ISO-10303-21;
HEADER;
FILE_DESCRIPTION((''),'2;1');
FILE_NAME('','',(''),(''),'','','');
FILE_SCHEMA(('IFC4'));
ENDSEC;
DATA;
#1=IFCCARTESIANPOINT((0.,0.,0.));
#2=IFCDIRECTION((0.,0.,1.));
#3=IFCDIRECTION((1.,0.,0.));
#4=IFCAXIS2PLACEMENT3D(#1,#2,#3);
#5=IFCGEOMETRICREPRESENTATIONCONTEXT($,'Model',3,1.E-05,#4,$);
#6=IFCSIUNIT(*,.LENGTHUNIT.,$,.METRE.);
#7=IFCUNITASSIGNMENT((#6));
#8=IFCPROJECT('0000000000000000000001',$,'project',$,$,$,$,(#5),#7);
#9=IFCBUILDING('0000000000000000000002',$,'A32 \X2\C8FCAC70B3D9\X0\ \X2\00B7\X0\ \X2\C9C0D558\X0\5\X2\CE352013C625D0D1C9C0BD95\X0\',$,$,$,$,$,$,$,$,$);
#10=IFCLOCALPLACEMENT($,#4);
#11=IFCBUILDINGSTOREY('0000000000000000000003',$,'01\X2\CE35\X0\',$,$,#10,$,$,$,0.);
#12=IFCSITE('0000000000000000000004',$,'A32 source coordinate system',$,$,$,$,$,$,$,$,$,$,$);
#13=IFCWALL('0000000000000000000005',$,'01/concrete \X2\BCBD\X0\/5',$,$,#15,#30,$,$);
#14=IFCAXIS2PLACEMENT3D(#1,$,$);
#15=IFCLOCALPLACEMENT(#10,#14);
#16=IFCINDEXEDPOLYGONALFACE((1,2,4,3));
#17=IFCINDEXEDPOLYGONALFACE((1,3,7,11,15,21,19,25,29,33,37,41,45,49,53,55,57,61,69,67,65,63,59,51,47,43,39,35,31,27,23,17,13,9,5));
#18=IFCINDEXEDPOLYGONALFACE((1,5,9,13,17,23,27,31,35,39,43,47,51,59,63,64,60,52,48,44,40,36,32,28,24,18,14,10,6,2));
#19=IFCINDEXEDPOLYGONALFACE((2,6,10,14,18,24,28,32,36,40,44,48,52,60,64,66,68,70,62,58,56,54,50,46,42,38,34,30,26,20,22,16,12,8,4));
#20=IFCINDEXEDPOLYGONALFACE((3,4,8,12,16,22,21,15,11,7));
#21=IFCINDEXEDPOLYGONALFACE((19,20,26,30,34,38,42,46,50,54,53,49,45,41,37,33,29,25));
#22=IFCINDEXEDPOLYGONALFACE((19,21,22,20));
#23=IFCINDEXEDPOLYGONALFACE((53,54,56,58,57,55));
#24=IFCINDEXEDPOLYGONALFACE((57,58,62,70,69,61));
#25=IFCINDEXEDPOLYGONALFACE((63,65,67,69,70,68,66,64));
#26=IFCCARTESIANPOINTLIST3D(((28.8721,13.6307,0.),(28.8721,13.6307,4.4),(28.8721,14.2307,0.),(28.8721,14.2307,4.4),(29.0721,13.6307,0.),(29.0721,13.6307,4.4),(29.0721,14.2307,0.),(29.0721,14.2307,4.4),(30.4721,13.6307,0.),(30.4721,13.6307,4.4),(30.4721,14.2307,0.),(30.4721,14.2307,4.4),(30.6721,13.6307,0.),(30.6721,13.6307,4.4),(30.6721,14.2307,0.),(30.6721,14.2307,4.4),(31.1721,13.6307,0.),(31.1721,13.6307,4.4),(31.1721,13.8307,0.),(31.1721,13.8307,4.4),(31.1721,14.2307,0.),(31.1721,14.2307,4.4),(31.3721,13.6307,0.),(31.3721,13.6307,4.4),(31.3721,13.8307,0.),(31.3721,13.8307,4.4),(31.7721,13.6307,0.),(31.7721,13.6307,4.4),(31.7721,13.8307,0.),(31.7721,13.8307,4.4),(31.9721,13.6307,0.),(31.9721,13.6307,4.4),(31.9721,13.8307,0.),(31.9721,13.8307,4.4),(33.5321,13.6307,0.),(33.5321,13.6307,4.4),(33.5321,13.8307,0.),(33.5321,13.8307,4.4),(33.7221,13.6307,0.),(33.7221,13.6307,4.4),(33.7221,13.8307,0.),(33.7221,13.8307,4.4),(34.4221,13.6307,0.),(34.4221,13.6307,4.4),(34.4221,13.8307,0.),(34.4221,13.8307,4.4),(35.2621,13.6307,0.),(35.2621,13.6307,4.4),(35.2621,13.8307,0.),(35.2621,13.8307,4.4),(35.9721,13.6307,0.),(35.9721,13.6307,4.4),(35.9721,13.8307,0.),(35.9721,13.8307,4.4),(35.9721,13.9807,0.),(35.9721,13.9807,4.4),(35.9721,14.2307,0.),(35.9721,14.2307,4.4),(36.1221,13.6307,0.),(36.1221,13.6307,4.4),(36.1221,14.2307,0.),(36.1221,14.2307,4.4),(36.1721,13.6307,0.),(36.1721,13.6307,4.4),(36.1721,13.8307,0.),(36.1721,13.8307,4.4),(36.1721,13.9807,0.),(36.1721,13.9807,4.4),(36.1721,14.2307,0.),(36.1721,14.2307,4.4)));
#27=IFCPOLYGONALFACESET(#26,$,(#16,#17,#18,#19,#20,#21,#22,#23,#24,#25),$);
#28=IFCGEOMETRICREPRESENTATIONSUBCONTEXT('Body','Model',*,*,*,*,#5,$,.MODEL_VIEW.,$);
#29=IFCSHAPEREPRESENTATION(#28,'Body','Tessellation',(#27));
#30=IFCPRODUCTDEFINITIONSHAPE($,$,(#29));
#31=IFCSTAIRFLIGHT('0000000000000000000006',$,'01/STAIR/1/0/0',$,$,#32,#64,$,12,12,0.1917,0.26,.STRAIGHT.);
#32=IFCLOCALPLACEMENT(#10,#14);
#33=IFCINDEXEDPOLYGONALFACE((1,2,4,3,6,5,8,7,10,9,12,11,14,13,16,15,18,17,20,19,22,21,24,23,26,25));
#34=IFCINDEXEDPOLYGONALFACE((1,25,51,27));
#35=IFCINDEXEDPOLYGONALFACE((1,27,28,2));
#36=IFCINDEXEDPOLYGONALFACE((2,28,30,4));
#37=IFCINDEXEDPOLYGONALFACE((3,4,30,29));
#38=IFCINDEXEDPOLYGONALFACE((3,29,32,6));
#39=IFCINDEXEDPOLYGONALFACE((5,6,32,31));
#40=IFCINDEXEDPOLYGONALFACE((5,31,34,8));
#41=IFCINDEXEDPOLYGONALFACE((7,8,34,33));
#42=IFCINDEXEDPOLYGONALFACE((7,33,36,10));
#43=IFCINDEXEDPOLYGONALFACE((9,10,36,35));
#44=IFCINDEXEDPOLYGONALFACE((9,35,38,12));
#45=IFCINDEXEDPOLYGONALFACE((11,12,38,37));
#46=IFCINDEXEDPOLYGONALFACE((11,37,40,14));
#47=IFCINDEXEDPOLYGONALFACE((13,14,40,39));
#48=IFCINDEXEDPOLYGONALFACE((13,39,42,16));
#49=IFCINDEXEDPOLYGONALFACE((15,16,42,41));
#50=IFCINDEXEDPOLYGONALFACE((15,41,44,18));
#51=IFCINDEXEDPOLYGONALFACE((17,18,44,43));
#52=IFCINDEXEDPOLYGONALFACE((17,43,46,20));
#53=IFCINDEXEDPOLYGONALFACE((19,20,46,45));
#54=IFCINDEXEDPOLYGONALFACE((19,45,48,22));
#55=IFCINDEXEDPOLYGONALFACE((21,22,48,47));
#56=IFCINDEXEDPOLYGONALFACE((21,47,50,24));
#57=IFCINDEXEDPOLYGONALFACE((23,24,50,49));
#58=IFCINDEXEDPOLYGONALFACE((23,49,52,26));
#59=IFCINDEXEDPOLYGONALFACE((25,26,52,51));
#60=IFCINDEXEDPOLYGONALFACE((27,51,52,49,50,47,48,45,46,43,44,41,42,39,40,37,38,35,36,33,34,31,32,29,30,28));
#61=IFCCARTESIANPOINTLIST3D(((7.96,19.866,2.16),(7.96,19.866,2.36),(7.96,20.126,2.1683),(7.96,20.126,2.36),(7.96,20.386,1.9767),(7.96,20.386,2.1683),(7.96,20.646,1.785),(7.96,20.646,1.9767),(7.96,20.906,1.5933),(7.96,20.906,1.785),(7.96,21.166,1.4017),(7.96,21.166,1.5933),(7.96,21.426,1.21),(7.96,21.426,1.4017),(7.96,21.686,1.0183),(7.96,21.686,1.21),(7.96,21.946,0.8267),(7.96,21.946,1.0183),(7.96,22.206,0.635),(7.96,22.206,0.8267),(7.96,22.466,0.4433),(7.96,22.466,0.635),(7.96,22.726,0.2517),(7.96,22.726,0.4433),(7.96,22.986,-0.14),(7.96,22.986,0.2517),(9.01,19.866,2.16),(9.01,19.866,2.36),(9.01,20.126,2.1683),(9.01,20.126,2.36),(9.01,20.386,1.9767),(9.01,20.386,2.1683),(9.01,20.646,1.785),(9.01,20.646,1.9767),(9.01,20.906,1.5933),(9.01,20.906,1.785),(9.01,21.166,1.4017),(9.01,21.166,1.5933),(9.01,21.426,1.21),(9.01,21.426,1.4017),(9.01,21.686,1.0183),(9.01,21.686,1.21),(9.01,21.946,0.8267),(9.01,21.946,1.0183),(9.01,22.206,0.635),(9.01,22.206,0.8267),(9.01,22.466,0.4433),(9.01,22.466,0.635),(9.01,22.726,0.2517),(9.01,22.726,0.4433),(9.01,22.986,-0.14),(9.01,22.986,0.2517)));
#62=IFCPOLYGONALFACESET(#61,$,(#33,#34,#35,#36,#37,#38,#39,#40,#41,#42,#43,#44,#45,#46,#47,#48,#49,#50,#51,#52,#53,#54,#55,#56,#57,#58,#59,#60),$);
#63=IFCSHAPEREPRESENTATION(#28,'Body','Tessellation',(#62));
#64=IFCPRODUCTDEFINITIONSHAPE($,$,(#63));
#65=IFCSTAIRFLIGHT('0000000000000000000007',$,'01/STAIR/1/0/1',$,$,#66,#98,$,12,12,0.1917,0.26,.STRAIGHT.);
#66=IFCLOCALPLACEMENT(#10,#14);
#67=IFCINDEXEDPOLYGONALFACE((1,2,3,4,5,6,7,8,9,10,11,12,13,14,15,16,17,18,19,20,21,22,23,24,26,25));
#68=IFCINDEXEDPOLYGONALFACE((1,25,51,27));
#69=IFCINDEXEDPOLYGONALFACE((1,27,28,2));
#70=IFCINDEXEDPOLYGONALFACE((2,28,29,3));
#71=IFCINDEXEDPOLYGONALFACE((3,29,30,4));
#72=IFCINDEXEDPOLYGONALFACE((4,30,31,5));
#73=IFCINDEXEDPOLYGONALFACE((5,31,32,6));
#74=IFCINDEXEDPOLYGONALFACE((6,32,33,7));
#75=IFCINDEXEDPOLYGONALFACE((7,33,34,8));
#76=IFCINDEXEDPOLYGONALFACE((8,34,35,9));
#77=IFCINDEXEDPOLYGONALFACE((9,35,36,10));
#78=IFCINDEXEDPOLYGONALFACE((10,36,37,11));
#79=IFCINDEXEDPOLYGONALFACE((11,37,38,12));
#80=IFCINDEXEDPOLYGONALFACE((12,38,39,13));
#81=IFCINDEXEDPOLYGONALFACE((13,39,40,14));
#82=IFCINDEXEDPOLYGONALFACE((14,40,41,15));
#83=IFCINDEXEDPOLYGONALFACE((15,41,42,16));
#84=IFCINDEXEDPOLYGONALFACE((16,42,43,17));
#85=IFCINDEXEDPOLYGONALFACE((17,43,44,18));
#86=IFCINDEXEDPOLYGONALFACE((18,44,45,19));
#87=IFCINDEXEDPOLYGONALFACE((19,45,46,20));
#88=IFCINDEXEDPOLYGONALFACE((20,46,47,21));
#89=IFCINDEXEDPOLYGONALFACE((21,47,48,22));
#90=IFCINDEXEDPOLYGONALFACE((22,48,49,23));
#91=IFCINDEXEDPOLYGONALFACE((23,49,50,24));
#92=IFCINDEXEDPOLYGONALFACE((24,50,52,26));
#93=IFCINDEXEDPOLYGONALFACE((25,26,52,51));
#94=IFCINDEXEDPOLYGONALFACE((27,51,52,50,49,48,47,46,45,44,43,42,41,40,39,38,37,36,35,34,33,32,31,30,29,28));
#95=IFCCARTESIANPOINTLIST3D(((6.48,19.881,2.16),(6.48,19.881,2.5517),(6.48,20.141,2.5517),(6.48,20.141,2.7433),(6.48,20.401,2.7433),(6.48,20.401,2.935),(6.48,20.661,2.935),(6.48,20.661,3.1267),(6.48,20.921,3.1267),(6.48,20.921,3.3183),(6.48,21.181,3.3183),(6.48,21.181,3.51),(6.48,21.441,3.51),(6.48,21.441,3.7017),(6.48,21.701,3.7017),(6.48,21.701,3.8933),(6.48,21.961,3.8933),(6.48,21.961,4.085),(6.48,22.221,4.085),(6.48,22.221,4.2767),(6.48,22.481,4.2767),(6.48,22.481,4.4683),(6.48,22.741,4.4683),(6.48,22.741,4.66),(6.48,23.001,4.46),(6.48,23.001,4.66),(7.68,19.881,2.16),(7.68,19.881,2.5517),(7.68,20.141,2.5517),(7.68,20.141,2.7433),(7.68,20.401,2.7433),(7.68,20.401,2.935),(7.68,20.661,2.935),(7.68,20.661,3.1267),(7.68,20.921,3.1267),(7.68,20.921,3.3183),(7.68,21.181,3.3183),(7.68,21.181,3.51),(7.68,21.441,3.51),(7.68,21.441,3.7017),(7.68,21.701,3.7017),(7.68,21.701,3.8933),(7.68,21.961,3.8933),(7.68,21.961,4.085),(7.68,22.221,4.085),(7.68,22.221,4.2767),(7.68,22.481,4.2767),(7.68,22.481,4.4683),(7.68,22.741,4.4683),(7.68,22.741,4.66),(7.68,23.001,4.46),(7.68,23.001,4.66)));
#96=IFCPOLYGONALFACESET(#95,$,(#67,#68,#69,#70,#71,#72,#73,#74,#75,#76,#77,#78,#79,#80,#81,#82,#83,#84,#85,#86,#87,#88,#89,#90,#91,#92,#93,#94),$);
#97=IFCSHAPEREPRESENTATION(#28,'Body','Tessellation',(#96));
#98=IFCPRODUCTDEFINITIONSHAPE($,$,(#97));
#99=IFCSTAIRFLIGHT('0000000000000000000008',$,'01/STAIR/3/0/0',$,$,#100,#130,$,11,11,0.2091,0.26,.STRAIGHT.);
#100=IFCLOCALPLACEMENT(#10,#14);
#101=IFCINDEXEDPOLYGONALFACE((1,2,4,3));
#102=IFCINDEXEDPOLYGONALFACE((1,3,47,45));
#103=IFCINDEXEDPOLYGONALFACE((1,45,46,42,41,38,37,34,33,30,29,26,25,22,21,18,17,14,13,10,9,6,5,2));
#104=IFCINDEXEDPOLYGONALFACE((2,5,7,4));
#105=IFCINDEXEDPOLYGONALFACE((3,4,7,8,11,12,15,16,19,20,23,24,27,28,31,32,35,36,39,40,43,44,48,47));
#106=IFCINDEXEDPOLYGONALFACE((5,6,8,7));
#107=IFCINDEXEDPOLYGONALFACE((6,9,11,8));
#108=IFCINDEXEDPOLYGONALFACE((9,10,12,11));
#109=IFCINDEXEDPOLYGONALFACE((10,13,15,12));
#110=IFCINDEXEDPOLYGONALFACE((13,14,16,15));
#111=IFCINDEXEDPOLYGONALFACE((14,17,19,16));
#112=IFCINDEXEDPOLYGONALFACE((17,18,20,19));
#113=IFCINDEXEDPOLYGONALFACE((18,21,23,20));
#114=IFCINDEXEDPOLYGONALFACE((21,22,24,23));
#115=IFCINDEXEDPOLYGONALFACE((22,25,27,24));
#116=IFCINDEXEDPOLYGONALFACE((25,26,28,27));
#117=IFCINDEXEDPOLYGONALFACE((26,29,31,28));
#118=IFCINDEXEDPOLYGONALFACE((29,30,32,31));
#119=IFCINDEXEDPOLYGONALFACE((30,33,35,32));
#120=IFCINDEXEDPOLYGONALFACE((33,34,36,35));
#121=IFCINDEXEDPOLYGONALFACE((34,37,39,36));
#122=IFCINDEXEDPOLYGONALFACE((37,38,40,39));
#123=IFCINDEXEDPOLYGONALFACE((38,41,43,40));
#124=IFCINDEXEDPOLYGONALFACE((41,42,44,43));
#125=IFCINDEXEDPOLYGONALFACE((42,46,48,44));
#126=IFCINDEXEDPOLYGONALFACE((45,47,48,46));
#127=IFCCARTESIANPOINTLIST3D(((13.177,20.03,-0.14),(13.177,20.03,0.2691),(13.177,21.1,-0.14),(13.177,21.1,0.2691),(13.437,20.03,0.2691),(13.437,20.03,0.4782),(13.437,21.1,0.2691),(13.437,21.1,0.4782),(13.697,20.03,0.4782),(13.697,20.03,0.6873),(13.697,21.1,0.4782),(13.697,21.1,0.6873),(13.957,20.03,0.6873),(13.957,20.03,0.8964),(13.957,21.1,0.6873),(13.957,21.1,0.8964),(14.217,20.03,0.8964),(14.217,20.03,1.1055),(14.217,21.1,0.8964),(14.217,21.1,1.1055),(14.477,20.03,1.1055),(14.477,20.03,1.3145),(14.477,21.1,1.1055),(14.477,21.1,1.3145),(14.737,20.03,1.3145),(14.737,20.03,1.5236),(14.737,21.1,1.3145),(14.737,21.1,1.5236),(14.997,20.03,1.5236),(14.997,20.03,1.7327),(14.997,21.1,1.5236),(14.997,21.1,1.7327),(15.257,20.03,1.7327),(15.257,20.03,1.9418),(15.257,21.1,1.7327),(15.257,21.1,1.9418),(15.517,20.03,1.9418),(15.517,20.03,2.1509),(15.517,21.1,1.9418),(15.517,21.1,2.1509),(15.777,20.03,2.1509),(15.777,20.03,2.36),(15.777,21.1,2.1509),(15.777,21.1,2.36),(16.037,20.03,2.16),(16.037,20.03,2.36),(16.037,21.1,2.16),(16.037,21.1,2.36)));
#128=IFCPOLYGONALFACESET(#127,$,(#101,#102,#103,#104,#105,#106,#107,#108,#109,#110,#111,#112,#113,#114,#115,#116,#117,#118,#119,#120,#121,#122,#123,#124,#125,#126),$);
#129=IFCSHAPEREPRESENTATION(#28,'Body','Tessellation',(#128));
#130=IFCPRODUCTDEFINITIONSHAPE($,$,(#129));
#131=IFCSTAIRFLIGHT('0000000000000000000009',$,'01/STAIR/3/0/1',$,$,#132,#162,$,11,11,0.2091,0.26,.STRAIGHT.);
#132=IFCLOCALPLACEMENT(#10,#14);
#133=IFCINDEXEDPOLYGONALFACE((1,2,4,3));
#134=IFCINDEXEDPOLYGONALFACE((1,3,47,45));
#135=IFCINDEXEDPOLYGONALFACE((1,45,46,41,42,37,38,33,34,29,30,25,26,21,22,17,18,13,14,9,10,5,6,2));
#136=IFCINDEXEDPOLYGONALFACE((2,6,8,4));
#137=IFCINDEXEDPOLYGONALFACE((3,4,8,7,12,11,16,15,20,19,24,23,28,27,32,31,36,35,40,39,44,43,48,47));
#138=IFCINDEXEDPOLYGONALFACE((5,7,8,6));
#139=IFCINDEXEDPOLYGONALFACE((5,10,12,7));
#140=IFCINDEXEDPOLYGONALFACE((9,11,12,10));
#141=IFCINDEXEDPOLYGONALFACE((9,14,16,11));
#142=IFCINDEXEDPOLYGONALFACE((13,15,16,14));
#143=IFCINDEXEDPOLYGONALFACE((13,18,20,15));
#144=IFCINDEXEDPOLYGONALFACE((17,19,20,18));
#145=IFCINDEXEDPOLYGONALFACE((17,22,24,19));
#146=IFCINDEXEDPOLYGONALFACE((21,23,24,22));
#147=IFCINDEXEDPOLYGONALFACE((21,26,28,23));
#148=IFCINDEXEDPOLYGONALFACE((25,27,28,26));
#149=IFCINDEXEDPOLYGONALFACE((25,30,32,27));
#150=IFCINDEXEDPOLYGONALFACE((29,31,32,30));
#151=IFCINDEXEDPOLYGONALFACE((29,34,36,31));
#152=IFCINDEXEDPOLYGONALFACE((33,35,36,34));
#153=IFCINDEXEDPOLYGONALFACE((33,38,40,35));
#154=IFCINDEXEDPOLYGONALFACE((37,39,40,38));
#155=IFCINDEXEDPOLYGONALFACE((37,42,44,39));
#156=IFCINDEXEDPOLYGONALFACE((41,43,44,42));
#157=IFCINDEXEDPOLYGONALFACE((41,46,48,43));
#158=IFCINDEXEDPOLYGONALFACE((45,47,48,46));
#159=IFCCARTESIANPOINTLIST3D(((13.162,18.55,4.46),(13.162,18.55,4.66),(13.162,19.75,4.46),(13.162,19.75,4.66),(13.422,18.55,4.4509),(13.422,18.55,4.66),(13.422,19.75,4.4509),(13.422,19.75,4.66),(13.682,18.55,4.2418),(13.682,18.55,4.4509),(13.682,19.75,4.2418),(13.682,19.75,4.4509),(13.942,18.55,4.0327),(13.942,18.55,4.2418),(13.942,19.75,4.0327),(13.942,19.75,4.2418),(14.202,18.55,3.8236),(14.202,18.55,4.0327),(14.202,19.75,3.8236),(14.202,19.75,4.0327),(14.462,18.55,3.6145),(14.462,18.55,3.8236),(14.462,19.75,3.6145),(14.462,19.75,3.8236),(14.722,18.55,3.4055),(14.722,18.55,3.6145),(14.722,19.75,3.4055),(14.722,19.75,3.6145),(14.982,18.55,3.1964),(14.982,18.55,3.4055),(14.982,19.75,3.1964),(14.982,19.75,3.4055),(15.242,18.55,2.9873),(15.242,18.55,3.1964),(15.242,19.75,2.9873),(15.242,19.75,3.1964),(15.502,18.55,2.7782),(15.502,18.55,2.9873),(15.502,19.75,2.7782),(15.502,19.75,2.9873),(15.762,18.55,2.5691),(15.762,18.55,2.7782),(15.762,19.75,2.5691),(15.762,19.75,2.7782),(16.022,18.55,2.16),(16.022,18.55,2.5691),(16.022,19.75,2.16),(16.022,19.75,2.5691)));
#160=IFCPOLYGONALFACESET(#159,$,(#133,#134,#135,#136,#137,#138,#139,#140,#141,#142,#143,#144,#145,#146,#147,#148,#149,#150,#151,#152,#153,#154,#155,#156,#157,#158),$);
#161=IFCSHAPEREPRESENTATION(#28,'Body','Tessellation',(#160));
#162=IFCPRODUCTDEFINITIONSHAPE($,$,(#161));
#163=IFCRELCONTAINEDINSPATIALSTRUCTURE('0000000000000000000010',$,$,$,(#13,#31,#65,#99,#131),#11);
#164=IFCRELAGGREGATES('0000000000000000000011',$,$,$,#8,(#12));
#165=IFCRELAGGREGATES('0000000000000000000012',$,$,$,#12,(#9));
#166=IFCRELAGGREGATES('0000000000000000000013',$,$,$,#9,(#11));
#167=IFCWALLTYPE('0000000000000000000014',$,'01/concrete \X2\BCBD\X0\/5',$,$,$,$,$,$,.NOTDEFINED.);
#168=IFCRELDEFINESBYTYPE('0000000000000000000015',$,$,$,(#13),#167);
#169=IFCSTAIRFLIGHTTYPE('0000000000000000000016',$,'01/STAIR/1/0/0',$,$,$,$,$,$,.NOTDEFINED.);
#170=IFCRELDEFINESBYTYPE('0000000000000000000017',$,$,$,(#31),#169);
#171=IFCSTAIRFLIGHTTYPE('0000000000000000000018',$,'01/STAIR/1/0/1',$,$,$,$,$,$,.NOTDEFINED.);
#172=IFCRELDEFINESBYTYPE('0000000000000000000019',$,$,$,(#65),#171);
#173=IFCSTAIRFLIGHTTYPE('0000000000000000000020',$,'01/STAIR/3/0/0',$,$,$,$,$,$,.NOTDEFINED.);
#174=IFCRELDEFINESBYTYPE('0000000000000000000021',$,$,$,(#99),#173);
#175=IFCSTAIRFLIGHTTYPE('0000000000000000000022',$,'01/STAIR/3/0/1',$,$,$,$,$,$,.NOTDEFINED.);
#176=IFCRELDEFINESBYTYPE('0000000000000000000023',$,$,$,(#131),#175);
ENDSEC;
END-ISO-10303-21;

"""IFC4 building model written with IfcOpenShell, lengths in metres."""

from ifc_helpers import new_model, si_unit, frame, origin, origin_with_axes, place, context, subcontext, project, spatial, polyline, outline, extrude, source, transform, mapped, type_object, type_shapes, element, save


model = new_model("IFC4")

# Units and contexts
model_context = context("Model", 3, precision=1e-05, world=origin_with_axes())
body_context = subcontext(model_context, "Body", "Model", "MODEL_VIEW")
ifc_project = project(units=[si_unit("LENGTHUNIT", "METRE")], contexts=[model_context])

# Site, building, storey
storey_placement = place(None, origin_with_axes())
site = spatial("IfcSite", under=ifc_project, Name="A32 source coordinate system")
building = spatial("IfcBuilding", under=site, Name="A32 주거동 · 지하5층–옥탑지붕")
storey = spatial("IfcBuildingStorey", under=building, at=storey_placement, Name="01층", Elevation=0.0)

# Wall
wall_type_1 = type_object("IfcWallType", Name="01/concrete 벽/5", PredefinedType="NOTDEFINED")
shared_shape_1 = source(origin(), body_context, "Body", "SweptSolid", [
    extrude(outline(polyline([(31.3721, 13.8307), (31.7721, 13.8307), (31.9721, 13.8307), (33.5321, 13.8307), (33.7221, 13.8307), (34.4221, 13.8307), (35.2621, 13.8307), (35.9721, 13.8307), (35.9721, 13.9807), (35.9721, 14.2307), (36.1221, 14.2307), (36.1721, 14.2307), (36.1721, 13.9807), (36.1721, 13.8307), (36.1721, 13.6307), (36.1221, 13.6307), (35.9721, 13.6307), (35.2621, 13.6307), (34.4221, 13.6307), (33.7221, 13.6307), (33.5321, 13.6307), (31.9721, 13.6307), (31.7721, 13.6307), (31.3721, 13.6307), (31.1721, 13.6307), (30.6721, 13.6307), (30.4721, 13.6307), (29.0721, 13.6307), (28.8721, 13.6307), (28.8721, 14.2307), (29.0721, 14.2307), (30.4721, 14.2307), (30.6721, 14.2307), (31.1721, 14.2307), (31.1721, 13.8307), (31.3721, 13.8307)])), origin(), (0.0, 0.0, 1.0), 4.4),
])
type_shapes(wall_type_1, [shared_shape_1])
wall_1_placement = place(storey_placement, origin_with_axes())
element("IfcWall", 1, at=wall_1_placement, inside=storey, type_object=wall_type_1, Name="01/concrete 벽/5", context=body_context, shape_type="MappedRepresentation", body=[
    mapped(shared_shape_1, transform((0.0, 0.0, 0.0), scale=1.0)),
])

# Stair flights
stair_flight_type_1 = type_object("IfcStairFlightType", Name="01/STAIR/1/0/0", PredefinedType="NOTDEFINED")
shared_shape_2 = source(origin(), body_context, "Body", "SweptSolid", [
    extrude(outline(polyline([(0.0, -0.14), (3.12, 2.16), (3.12, 2.36), (2.86, 2.36), (2.86, 2.1683), (2.6, 2.1683), (2.6, 1.9767), (2.34, 1.9767), (2.34, 1.785), (2.08, 1.785), (2.08, 1.5933), (1.82, 1.5933), (1.82, 1.4017), (1.56, 1.4017), (1.56, 1.21), (1.3, 1.21), (1.3, 1.0183), (1.04, 1.0183), (1.04, 0.8267), (0.78, 0.8267), (0.78, 0.635), (0.52, 0.635), (0.52, 0.4433), (0.26, 0.4433), (0.26, 0.2517), (0.0, 0.2517), (0.0, -0.14)])), frame((9.01, 22.986, 0.0), z_axis=(-1.0, 0.0, 0.0), x_axis=(0.0, -1.0, 0.0)), (0.0, 0.0, 1.0), 1.05),
])
type_shapes(stair_flight_type_1, [shared_shape_2])
stair_flight_1_placement = place(storey_placement, origin_with_axes())
element("IfcStairFlight", 2, at=stair_flight_1_placement, inside=storey, type_object=stair_flight_type_1, Name="01/STAIR/1/0/0", NumberOfRisers=12, NumberOfTreads=12, PredefinedType="STRAIGHT", RiserHeight=0.1917, TreadLength=0.26, context=body_context, shape_type="MappedRepresentation", body=[
    mapped(shared_shape_2, transform((0.0, 0.0, 0.0), scale=1.0)),
])
stair_flight_type_2 = type_object("IfcStairFlightType", Name="01/STAIR/1/0/1", PredefinedType="NOTDEFINED")
shared_shape_3 = source(origin(), body_context, "Body", "SweptSolid", [
    extrude(outline(polyline([(0.0, 2.16), (3.12, 4.46), (3.12, 4.66), (2.86, 4.66), (2.86, 4.4683), (2.6, 4.4683), (2.6, 4.2767), (2.34, 4.2767), (2.34, 4.085), (2.08, 4.085), (2.08, 3.8933), (1.82, 3.8933), (1.82, 3.7017), (1.56, 3.7017), (1.56, 3.51), (1.3, 3.51), (1.3, 3.3183), (1.04, 3.3183), (1.04, 3.1267), (0.78, 3.1267), (0.78, 2.935), (0.52, 2.935), (0.52, 2.7433), (0.26, 2.7433), (0.26, 2.5517), (0.0, 2.5517), (0.0, 2.16)])), frame((6.48, 19.881, 0.0), z_axis=(1.0, 0.0, 0.0), x_axis=(0.0, 1.0, 0.0)), (0.0, 0.0, 1.0), 1.2),
])
type_shapes(stair_flight_type_2, [shared_shape_3])
stair_flight_2_placement = place(storey_placement, origin_with_axes())
element("IfcStairFlight", 3, at=stair_flight_2_placement, inside=storey, type_object=stair_flight_type_2, Name="01/STAIR/1/0/1", NumberOfRisers=12, NumberOfTreads=12, PredefinedType="STRAIGHT", RiserHeight=0.1917, TreadLength=0.26, context=body_context, shape_type="MappedRepresentation", body=[
    mapped(shared_shape_3, transform((0.0, 0.0, 0.0), scale=1.0)),
])
stair_flight_type_3 = type_object("IfcStairFlightType", Name="01/STAIR/3/0/0", PredefinedType="NOTDEFINED")
shared_shape_4 = source(origin(), body_context, "Body", "SweptSolid", [
    extrude(outline(polyline([(0.0, -0.14), (2.86, 2.16), (2.86, 2.36), (2.6, 2.36), (2.6, 2.1509), (2.34, 2.1509), (2.34, 1.9418), (2.08, 1.9418), (2.08, 1.7327), (1.82, 1.7327), (1.82, 1.5236), (1.56, 1.5236), (1.56, 1.3145), (1.3, 1.3145), (1.3, 1.1055), (1.04, 1.1055), (1.04, 0.8964), (0.78, 0.8964), (0.78, 0.6873), (0.52, 0.6873), (0.52, 0.4782), (0.26, 0.4782), (0.26, 0.2691), (0.0, 0.2691), (0.0, -0.14)])), frame((13.177, 21.1, 0.0), z_axis=(0.0, -1.0, 0.0), x_axis=(1.0, 0.0, 0.0)), (0.0, 0.0, 1.0), 1.07),
])
type_shapes(stair_flight_type_3, [shared_shape_4])
stair_flight_3_placement = place(storey_placement, origin_with_axes())
element("IfcStairFlight", 4, at=stair_flight_3_placement, inside=storey, type_object=stair_flight_type_3, Name="01/STAIR/3/0/0", NumberOfRisers=11, NumberOfTreads=11, PredefinedType="STRAIGHT", RiserHeight=0.2091, TreadLength=0.26, context=body_context, shape_type="MappedRepresentation", body=[
    mapped(shared_shape_4, transform((0.0, 0.0, 0.0), scale=1.0)),
])
stair_flight_type_4 = type_object("IfcStairFlightType", Name="01/STAIR/3/0/1", PredefinedType="NOTDEFINED")
shared_shape_5 = source(origin(), body_context, "Body", "SweptSolid", [
    extrude(outline(polyline([(0.0, 2.16), (2.86, 4.46), (2.86, 4.66), (2.6, 4.66), (2.6, 4.4509), (2.34, 4.4509), (2.34, 4.2418), (2.08, 4.2418), (2.08, 4.0327), (1.82, 4.0327), (1.82, 3.8236), (1.56, 3.8236), (1.56, 3.6145), (1.3, 3.6145), (1.3, 3.4055), (1.04, 3.4055), (1.04, 3.1964), (0.78, 3.1964), (0.78, 2.9873), (0.52, 2.9873), (0.52, 2.7782), (0.26, 2.7782), (0.26, 2.5691), (0.0, 2.5691), (0.0, 2.16)])), frame((16.022, 18.55, 0.0), z_axis=(0.0, 1.0, 0.0), x_axis=(-1.0, 0.0, 0.0)), (0.0, 0.0, 1.0), 1.2),
])
type_shapes(stair_flight_type_4, [shared_shape_5])
stair_flight_4_placement = place(storey_placement, origin_with_axes())
element("IfcStairFlight", 5, at=stair_flight_4_placement, inside=storey, type_object=stair_flight_type_4, Name="01/STAIR/3/0/1", NumberOfRisers=11, NumberOfTreads=11, PredefinedType="STRAIGHT", RiserHeight=0.2091, TreadLength=0.26, context=body_context, shape_type="MappedRepresentation", body=[
    mapped(shared_shape_5, transform((0.0, 0.0, 0.0), scale=1.0)),
])

save(model, "model.ifc")
